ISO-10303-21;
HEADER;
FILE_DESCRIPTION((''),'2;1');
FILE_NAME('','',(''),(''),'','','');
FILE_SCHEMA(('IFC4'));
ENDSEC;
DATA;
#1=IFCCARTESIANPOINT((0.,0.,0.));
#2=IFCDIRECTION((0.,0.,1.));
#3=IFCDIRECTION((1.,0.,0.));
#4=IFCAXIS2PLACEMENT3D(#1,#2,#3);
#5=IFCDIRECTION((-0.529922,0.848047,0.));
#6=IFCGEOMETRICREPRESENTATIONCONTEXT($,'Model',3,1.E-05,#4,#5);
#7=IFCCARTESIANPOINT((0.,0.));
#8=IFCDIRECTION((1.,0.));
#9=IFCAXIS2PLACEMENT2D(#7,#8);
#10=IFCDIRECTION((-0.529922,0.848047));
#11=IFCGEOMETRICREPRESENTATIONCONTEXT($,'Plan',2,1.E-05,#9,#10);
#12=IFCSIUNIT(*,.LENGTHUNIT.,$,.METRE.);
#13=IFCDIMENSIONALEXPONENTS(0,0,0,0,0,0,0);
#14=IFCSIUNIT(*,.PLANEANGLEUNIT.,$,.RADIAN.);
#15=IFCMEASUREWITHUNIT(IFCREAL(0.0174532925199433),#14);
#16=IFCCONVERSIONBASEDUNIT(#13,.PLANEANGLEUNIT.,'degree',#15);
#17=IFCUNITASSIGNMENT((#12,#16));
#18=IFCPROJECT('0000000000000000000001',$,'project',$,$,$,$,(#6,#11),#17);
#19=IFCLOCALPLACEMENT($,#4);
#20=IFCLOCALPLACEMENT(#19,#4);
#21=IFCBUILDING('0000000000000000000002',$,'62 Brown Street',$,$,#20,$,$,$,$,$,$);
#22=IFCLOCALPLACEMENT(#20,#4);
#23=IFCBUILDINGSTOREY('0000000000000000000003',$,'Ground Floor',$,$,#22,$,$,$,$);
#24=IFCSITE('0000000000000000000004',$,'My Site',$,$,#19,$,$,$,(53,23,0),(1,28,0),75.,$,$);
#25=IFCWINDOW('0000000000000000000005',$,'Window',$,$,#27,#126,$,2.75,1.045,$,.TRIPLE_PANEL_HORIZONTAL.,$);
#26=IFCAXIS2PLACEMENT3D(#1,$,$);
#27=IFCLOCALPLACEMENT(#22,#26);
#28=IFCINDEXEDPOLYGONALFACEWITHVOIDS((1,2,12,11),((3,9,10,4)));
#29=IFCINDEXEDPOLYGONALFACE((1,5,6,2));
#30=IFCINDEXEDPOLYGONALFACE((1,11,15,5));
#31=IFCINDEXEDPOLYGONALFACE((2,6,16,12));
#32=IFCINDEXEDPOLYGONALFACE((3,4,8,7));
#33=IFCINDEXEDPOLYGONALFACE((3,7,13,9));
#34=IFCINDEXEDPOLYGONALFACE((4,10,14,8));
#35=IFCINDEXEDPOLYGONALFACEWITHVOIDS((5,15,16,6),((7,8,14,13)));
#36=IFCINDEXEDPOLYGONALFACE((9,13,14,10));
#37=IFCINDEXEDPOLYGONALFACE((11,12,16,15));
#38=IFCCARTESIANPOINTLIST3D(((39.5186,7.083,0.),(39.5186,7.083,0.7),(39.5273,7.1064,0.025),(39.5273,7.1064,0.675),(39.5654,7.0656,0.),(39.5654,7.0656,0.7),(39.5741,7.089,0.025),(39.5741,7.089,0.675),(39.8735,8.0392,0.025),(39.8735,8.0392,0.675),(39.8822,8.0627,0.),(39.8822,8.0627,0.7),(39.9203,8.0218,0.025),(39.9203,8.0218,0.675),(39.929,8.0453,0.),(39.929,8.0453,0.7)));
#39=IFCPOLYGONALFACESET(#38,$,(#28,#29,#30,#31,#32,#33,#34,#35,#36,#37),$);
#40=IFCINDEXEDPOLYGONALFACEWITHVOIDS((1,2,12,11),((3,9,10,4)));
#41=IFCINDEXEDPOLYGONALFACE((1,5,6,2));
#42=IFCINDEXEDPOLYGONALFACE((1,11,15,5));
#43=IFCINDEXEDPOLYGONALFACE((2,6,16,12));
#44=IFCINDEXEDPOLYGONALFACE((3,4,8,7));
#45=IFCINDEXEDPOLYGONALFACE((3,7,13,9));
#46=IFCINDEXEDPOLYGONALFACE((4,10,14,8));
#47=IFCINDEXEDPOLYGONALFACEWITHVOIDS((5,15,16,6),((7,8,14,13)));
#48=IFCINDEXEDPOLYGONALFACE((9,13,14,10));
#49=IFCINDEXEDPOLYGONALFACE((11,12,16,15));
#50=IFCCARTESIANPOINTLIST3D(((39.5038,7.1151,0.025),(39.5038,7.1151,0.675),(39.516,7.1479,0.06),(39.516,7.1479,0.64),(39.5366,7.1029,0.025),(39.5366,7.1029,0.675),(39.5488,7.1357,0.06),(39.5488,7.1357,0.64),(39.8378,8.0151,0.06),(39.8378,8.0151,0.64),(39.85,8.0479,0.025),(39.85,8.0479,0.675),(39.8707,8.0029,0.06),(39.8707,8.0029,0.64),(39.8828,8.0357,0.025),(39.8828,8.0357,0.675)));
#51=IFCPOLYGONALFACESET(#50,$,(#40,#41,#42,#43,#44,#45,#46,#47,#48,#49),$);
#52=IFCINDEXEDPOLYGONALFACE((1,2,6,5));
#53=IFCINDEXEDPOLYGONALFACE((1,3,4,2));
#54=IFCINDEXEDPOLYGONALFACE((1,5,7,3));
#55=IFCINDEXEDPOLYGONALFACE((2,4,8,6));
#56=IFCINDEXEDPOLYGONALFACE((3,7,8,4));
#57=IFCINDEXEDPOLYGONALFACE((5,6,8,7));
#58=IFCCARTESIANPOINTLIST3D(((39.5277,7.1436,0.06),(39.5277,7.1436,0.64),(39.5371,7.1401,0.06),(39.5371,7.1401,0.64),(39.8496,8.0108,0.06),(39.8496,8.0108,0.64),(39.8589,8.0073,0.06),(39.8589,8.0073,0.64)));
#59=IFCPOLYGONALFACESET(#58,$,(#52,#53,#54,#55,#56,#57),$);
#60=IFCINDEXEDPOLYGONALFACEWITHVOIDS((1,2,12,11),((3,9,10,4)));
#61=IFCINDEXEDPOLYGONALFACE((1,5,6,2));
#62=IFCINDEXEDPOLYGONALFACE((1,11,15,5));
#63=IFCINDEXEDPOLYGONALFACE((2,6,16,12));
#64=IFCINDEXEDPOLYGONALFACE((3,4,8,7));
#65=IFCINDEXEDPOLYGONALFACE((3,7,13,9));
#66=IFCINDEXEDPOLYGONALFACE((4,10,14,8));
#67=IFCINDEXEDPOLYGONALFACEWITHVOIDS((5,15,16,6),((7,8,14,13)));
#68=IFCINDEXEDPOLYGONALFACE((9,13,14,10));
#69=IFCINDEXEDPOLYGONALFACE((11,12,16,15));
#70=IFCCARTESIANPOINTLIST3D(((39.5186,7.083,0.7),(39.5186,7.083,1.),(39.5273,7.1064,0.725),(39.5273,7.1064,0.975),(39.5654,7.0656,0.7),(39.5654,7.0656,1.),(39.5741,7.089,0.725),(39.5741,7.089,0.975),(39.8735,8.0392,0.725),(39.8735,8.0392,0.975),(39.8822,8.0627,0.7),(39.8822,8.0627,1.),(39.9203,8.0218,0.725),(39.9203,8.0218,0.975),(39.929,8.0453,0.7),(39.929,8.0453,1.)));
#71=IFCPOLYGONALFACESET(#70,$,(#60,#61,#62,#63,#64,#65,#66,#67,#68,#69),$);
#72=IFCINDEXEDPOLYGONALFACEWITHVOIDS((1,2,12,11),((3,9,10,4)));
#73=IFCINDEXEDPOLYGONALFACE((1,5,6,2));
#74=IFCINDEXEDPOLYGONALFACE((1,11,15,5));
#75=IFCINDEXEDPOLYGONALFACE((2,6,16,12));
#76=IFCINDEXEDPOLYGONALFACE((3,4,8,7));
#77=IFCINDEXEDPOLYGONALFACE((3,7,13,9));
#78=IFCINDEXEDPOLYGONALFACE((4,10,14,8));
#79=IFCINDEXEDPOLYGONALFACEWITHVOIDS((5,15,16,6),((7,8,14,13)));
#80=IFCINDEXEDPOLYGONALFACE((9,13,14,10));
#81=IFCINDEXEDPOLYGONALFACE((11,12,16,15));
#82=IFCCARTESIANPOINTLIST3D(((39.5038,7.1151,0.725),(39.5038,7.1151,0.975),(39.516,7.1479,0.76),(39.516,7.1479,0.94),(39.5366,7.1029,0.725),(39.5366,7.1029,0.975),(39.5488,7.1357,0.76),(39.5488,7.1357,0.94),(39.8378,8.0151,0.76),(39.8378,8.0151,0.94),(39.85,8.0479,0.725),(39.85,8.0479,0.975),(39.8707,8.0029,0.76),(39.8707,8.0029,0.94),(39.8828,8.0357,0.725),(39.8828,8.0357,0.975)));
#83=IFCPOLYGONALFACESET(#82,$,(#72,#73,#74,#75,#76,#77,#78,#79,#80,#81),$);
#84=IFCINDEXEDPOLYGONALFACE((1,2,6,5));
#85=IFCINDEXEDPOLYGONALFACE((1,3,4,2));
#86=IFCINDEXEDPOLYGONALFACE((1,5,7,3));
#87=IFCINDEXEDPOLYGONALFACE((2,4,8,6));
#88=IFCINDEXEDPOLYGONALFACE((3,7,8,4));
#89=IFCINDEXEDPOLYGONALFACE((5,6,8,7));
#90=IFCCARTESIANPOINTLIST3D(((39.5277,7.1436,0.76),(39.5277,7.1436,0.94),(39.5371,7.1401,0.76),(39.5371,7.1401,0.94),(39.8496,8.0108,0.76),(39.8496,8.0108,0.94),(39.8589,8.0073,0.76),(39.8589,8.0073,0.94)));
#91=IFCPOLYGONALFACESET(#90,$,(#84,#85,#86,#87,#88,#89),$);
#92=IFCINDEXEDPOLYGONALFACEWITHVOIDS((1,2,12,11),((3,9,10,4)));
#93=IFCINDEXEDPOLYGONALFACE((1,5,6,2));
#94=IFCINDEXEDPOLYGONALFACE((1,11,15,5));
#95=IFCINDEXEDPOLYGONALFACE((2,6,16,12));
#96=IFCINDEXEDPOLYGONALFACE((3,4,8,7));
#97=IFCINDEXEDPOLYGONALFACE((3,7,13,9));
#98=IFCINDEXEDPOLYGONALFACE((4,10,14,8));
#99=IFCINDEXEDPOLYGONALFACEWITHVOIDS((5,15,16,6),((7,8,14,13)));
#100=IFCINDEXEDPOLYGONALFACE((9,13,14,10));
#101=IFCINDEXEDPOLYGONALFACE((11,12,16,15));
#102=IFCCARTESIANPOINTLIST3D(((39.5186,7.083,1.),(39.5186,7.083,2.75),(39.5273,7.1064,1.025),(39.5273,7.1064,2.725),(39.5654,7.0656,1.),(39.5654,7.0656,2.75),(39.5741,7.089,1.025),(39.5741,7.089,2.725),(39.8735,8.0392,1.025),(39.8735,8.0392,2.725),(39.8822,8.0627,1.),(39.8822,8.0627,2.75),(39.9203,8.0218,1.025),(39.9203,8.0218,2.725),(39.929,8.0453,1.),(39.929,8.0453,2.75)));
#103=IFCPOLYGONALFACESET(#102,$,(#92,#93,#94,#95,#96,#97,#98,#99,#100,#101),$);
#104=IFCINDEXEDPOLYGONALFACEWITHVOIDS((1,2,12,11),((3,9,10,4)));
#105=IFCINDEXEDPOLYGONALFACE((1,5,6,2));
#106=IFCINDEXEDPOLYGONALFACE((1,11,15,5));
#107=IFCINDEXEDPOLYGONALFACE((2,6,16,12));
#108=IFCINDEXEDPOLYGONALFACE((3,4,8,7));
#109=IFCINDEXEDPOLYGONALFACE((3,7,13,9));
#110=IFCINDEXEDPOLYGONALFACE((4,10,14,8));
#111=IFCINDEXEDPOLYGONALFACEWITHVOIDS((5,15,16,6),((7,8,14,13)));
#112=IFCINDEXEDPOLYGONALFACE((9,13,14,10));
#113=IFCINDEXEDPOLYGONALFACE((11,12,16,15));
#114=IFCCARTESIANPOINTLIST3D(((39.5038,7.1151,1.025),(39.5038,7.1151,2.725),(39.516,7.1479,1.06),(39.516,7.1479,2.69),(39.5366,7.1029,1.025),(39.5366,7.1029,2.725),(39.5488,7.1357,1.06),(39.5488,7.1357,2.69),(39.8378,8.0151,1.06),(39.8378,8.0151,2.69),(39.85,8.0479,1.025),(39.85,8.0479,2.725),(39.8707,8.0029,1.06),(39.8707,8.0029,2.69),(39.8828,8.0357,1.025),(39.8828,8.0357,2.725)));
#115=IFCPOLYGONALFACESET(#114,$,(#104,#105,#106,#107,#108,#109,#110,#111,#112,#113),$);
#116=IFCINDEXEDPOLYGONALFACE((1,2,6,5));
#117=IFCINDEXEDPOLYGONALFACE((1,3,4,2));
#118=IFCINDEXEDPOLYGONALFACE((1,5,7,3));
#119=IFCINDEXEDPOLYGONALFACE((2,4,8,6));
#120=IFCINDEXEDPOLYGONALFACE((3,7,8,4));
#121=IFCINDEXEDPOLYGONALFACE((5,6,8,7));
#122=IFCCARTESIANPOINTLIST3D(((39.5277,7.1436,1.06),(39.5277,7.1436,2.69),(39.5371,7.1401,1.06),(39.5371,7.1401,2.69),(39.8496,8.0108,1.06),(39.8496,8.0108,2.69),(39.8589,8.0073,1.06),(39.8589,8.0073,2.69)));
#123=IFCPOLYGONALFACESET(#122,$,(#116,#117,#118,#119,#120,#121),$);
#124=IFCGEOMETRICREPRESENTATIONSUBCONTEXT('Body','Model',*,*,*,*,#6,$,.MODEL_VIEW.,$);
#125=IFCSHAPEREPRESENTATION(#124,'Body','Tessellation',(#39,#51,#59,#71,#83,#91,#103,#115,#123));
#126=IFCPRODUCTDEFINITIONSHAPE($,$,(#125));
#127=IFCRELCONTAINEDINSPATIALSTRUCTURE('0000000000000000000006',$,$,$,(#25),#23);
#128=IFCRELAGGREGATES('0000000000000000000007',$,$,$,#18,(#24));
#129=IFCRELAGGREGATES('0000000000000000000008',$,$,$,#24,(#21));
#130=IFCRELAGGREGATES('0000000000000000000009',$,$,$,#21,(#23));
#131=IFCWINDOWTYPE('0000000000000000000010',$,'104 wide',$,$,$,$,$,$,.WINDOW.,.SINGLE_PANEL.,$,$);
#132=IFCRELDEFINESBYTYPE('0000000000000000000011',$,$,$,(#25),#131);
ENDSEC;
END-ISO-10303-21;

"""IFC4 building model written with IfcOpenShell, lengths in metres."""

from ifc_helpers import new_model, entity, si_unit, converted_unit, direction, frame, origin_with_axes, origin_2d_with_axis, place, context, subcontext, project, spatial, line, indexed_curve, outline, extrude, shape, source, transform, mapped, type_object, type_shapes, element, save


model = new_model("IFC4")

# Units and contexts
model_context = context("Model", 3, precision=1e-05, world=origin_with_axes(), true_north=direction((-0.529922, 0.848047, 0.0)))
plan_context = context("Plan", 2, precision=1e-05, world=origin_2d_with_axis(), true_north=direction((-0.529922, 0.848047)))
body_context_1 = subcontext(model_context, "Body", "Model", "MODEL_VIEW")
body_context_2 = subcontext(plan_context, "Body", "Plan", "PLAN_VIEW")
ifc_project = project(units=[si_unit("LENGTHUNIT", "METRE"), converted_unit("PLANEANGLEUNIT", "degree", entity("IfcReal", 0.0174532925199433), si_unit("PLANEANGLEUNIT", "RADIAN"), dimensions=[0, 0, 0, 0, 0, 0, 0])], contexts=[model_context, plan_context])

# Site, building, storey
site_placement = place(None, origin_with_axes())
site = spatial("IfcSite", under=ifc_project, at=site_placement, Name="My Site", RefLatitude=(53, 23, 0), RefLongitude=(1, 28, 0), RefElevation=75.0)
building_placement = place(site_placement, origin_with_axes())
building = spatial("IfcBuilding", under=site, at=building_placement, Name="62 Brown Street")
storey_placement = place(building_placement, origin_with_axes())
storey = spatial("IfcBuildingStorey", under=building, at=storey_placement, Name="Ground Floor")

# Window
window_type_1 = type_object("IfcWindowType", Name="104 wide", PartitioningType="SINGLE_PANEL", PredefinedType="WINDOW")
shared_shape_1 = source(origin_with_axes(), body_context_1, "Body", "SweptSolid", [
    extrude(outline(indexed_curve([(0.0, 0.0), (1.045, 0.0), (1.045, 0.7), (0.0, 0.7)], segments=[line(1, 2, 3, 4, 1)]), holes=[indexed_curve([(0.025, 0.025), (1.02, 0.025), (1.02, 0.675), (0.025, 0.675)], segments=[line(1, 2, 3, 4, 1)])]), frame((0.0, 0.15, 0.0), z_axis=(0.0, -1.0, 0.0), x_axis=(1.0, 0.0, 0.0)), (0.0, 0.0, -1.0), 0.05),
    extrude(outline(indexed_curve([(0.0, 0.0), (0.995, 0.0), (0.995, 0.65), (0.0, 0.65)], segments=[line(1, 2, 3, 4, 1)]), holes=[indexed_curve([(0.035, 0.035), (0.96, 0.035), (0.96, 0.615), (0.035, 0.615)], segments=[line(1, 2, 3, 4, 1)])]), frame((0.025, 0.19, 0.025), z_axis=(0.0, -1.0, 0.0), x_axis=(1.0, 0.0, 0.0)), (0.0, 0.0, -1.0), 0.035),
    extrude(outline(indexed_curve([(0.035, 0.035), (0.96, 0.035), (0.96, 0.615), (0.035, 0.615)], segments=[line(1, 2, 3, 4, 1)])), frame((0.025, 0.2025, 0.025), z_axis=(0.0, -1.0, 0.0), x_axis=(1.0, 0.0, 0.0)), (0.0, 0.0, -1.0), 0.01),
    extrude(outline(indexed_curve([(0.0, 0.0), (1.045, 0.0), (1.045, 0.3), (0.0, 0.3)], segments=[line(1, 2, 3, 4, 1)]), holes=[indexed_curve([(0.025, 0.025), (1.02, 0.025), (1.02, 0.275), (0.025, 0.275)], segments=[line(1, 2, 3, 4, 1)])]), frame((0.0, 0.15, 0.7), z_axis=(0.0, -1.0, 0.0), x_axis=(1.0, 0.0, 0.0)), (0.0, 0.0, -1.0), 0.05),
    extrude(outline(indexed_curve([(0.0, 0.0), (0.995, 0.0), (0.995, 0.25), (0.0, 0.25)], segments=[line(1, 2, 3, 4, 1)]), holes=[indexed_curve([(0.035, 0.035), (0.96, 0.035), (0.96, 0.215), (0.035, 0.215)], segments=[line(1, 2, 3, 4, 1)])]), frame((0.025, 0.19, 0.725), z_axis=(0.0, -1.0, 0.0), x_axis=(1.0, 0.0, 0.0)), (0.0, 0.0, -1.0), 0.035),
    extrude(outline(indexed_curve([(0.035, 0.035), (0.96, 0.035), (0.96, 0.215), (0.035, 0.215)], segments=[line(1, 2, 3, 4, 1)])), frame((0.025, 0.2025, 0.725), z_axis=(0.0, -1.0, 0.0), x_axis=(1.0, 0.0, 0.0)), (0.0, 0.0, -1.0), 0.01),
    extrude(outline(indexed_curve([(0.0, 0.0), (1.045, 0.0), (1.045, 1.75), (0.0, 1.75)], segments=[line(1, 2, 3, 4, 1)]), holes=[indexed_curve([(0.025, 0.025), (1.02, 0.025), (1.02, 1.725), (0.025, 1.725)], segments=[line(1, 2, 3, 4, 1)])]), frame((0.0, 0.15, 1.0), z_axis=(0.0, -1.0, 0.0), x_axis=(1.0, 0.0, 0.0)), (0.0, 0.0, -1.0), 0.05),
    extrude(outline(indexed_curve([(0.0, 0.0), (0.995, 0.0), (0.995, 1.7), (0.0, 1.7)], segments=[line(1, 2, 3, 4, 1)]), holes=[indexed_curve([(0.035, 0.035), (0.96, 0.035), (0.96, 1.665), (0.035, 1.665)], segments=[line(1, 2, 3, 4, 1)])]), frame((0.025, 0.19, 1.025), z_axis=(0.0, -1.0, 0.0), x_axis=(1.0, 0.0, 0.0)), (0.0, 0.0, -1.0), 0.035),
    extrude(outline(indexed_curve([(0.035, 0.035), (0.96, 0.035), (0.96, 1.665), (0.035, 1.665)], segments=[line(1, 2, 3, 4, 1)])), frame((0.025, 0.2025, 1.025), z_axis=(0.0, -1.0, 0.0), x_axis=(1.0, 0.0, 0.0)), (0.0, 0.0, -1.0), 0.01),
])
shared_shape_2 = source(origin_with_axes(), body_context_2, "Body", "Curve2D", [
    entity("IfcIndexedPolyCurve", entity("IfcCartesianPointList2D", [[0.025, 0.15], [1.02, 0.15]])),
    entity("IfcIndexedPolyCurve", entity("IfcCartesianPointList2D", [[0.0, 0.2], [0.025, 0.2], [0.025, 0.15], [0.0, 0.15]]), [entity("IfcLineIndex", [1, 2, 3, 4, 1])]),
    entity("IfcIndexedPolyCurve", entity("IfcCartesianPointList2D", [[1.045, 0.2], [1.02, 0.2], [1.02, 0.15], [1.045, 0.15]]), [entity("IfcLineIndex", [1, 2, 3, 4, 1])]),
    entity("IfcIndexedPolyCurve", entity("IfcCartesianPointList2D", [[0.025, 0.19], [0.06, 0.19], [0.06, 0.225], [0.025, 0.225]]), [entity("IfcLineIndex", [1, 2, 3, 4, 1])]),
    entity("IfcIndexedPolyCurve", entity("IfcCartesianPointList2D", [[1.02, 0.19], [0.985, 0.19], [0.985, 0.225], [1.02, 0.225]]), [entity("IfcLineIndex", [1, 2, 3, 4, 1])]),
    entity("IfcIndexedPolyCurve", entity("IfcCartesianPointList2D", [[0.06, 0.19], [0.985, 0.19]])),
    entity("IfcIndexedPolyCurve", entity("IfcCartesianPointList2D", [[0.06, 0.225], [0.985, 0.225]])),
    entity("IfcIndexedPolyCurve", entity("IfcCartesianPointList2D", [[0.06, 0.2075], [0.985, 0.2075]])),
])
type_shapes(window_type_1, [shared_shape_1, shared_shape_2])
placement_1 = place(storey_placement, frame((39.024, 5.1755, 0.0), z_axis=(0.0, 0.0, 1.0), x_axis=(0.347944, 0.937515, 0.0)))
placement_2 = place(placement_1, frame((1.9604, 0.0, 0.0), z_axis=(0.0, 0.0, 1.0), x_axis=(1.0, 0.0, 0.0)))
for number, where, z_axis, x_axis, name in (
    (1, (0.0, 0.0, 0.0), (0.0, 0.0, 1.0), (1.0, 0.0, 0.0), "Window"),
):
    element("IfcWindow", number, at=place(placement_2, frame(where, z_axis=z_axis, x_axis=x_axis)), inside=storey, type_object=window_type_1, Name=name, OverallHeight=2.75, OverallWidth=1.045, PartitioningType="TRIPLE_PANEL_HORIZONTAL", shapes=[
        shape(body_context_1, "Body", "MappedRepresentation", [mapped(shared_shape_1, transform((0.0, 0.0, 0.0), x_axis=(1.0, 0.0, 0.0), y_axis=(0.0, 1.0, 0.0), z_axis=(0.0, 0.0, 1.0), scale=1.0))]),
        shape(body_context_2, "Body", "MappedRepresentation", [mapped(shared_shape_2, transform((0.0, 0.0, 0.0), x_axis=(1.0, 0.0, 0.0), y_axis=(0.0, 1.0, 0.0), z_axis=(0.0, 0.0, 1.0), scale=1.0))]),
    ])

save(model, "model.ifc")
